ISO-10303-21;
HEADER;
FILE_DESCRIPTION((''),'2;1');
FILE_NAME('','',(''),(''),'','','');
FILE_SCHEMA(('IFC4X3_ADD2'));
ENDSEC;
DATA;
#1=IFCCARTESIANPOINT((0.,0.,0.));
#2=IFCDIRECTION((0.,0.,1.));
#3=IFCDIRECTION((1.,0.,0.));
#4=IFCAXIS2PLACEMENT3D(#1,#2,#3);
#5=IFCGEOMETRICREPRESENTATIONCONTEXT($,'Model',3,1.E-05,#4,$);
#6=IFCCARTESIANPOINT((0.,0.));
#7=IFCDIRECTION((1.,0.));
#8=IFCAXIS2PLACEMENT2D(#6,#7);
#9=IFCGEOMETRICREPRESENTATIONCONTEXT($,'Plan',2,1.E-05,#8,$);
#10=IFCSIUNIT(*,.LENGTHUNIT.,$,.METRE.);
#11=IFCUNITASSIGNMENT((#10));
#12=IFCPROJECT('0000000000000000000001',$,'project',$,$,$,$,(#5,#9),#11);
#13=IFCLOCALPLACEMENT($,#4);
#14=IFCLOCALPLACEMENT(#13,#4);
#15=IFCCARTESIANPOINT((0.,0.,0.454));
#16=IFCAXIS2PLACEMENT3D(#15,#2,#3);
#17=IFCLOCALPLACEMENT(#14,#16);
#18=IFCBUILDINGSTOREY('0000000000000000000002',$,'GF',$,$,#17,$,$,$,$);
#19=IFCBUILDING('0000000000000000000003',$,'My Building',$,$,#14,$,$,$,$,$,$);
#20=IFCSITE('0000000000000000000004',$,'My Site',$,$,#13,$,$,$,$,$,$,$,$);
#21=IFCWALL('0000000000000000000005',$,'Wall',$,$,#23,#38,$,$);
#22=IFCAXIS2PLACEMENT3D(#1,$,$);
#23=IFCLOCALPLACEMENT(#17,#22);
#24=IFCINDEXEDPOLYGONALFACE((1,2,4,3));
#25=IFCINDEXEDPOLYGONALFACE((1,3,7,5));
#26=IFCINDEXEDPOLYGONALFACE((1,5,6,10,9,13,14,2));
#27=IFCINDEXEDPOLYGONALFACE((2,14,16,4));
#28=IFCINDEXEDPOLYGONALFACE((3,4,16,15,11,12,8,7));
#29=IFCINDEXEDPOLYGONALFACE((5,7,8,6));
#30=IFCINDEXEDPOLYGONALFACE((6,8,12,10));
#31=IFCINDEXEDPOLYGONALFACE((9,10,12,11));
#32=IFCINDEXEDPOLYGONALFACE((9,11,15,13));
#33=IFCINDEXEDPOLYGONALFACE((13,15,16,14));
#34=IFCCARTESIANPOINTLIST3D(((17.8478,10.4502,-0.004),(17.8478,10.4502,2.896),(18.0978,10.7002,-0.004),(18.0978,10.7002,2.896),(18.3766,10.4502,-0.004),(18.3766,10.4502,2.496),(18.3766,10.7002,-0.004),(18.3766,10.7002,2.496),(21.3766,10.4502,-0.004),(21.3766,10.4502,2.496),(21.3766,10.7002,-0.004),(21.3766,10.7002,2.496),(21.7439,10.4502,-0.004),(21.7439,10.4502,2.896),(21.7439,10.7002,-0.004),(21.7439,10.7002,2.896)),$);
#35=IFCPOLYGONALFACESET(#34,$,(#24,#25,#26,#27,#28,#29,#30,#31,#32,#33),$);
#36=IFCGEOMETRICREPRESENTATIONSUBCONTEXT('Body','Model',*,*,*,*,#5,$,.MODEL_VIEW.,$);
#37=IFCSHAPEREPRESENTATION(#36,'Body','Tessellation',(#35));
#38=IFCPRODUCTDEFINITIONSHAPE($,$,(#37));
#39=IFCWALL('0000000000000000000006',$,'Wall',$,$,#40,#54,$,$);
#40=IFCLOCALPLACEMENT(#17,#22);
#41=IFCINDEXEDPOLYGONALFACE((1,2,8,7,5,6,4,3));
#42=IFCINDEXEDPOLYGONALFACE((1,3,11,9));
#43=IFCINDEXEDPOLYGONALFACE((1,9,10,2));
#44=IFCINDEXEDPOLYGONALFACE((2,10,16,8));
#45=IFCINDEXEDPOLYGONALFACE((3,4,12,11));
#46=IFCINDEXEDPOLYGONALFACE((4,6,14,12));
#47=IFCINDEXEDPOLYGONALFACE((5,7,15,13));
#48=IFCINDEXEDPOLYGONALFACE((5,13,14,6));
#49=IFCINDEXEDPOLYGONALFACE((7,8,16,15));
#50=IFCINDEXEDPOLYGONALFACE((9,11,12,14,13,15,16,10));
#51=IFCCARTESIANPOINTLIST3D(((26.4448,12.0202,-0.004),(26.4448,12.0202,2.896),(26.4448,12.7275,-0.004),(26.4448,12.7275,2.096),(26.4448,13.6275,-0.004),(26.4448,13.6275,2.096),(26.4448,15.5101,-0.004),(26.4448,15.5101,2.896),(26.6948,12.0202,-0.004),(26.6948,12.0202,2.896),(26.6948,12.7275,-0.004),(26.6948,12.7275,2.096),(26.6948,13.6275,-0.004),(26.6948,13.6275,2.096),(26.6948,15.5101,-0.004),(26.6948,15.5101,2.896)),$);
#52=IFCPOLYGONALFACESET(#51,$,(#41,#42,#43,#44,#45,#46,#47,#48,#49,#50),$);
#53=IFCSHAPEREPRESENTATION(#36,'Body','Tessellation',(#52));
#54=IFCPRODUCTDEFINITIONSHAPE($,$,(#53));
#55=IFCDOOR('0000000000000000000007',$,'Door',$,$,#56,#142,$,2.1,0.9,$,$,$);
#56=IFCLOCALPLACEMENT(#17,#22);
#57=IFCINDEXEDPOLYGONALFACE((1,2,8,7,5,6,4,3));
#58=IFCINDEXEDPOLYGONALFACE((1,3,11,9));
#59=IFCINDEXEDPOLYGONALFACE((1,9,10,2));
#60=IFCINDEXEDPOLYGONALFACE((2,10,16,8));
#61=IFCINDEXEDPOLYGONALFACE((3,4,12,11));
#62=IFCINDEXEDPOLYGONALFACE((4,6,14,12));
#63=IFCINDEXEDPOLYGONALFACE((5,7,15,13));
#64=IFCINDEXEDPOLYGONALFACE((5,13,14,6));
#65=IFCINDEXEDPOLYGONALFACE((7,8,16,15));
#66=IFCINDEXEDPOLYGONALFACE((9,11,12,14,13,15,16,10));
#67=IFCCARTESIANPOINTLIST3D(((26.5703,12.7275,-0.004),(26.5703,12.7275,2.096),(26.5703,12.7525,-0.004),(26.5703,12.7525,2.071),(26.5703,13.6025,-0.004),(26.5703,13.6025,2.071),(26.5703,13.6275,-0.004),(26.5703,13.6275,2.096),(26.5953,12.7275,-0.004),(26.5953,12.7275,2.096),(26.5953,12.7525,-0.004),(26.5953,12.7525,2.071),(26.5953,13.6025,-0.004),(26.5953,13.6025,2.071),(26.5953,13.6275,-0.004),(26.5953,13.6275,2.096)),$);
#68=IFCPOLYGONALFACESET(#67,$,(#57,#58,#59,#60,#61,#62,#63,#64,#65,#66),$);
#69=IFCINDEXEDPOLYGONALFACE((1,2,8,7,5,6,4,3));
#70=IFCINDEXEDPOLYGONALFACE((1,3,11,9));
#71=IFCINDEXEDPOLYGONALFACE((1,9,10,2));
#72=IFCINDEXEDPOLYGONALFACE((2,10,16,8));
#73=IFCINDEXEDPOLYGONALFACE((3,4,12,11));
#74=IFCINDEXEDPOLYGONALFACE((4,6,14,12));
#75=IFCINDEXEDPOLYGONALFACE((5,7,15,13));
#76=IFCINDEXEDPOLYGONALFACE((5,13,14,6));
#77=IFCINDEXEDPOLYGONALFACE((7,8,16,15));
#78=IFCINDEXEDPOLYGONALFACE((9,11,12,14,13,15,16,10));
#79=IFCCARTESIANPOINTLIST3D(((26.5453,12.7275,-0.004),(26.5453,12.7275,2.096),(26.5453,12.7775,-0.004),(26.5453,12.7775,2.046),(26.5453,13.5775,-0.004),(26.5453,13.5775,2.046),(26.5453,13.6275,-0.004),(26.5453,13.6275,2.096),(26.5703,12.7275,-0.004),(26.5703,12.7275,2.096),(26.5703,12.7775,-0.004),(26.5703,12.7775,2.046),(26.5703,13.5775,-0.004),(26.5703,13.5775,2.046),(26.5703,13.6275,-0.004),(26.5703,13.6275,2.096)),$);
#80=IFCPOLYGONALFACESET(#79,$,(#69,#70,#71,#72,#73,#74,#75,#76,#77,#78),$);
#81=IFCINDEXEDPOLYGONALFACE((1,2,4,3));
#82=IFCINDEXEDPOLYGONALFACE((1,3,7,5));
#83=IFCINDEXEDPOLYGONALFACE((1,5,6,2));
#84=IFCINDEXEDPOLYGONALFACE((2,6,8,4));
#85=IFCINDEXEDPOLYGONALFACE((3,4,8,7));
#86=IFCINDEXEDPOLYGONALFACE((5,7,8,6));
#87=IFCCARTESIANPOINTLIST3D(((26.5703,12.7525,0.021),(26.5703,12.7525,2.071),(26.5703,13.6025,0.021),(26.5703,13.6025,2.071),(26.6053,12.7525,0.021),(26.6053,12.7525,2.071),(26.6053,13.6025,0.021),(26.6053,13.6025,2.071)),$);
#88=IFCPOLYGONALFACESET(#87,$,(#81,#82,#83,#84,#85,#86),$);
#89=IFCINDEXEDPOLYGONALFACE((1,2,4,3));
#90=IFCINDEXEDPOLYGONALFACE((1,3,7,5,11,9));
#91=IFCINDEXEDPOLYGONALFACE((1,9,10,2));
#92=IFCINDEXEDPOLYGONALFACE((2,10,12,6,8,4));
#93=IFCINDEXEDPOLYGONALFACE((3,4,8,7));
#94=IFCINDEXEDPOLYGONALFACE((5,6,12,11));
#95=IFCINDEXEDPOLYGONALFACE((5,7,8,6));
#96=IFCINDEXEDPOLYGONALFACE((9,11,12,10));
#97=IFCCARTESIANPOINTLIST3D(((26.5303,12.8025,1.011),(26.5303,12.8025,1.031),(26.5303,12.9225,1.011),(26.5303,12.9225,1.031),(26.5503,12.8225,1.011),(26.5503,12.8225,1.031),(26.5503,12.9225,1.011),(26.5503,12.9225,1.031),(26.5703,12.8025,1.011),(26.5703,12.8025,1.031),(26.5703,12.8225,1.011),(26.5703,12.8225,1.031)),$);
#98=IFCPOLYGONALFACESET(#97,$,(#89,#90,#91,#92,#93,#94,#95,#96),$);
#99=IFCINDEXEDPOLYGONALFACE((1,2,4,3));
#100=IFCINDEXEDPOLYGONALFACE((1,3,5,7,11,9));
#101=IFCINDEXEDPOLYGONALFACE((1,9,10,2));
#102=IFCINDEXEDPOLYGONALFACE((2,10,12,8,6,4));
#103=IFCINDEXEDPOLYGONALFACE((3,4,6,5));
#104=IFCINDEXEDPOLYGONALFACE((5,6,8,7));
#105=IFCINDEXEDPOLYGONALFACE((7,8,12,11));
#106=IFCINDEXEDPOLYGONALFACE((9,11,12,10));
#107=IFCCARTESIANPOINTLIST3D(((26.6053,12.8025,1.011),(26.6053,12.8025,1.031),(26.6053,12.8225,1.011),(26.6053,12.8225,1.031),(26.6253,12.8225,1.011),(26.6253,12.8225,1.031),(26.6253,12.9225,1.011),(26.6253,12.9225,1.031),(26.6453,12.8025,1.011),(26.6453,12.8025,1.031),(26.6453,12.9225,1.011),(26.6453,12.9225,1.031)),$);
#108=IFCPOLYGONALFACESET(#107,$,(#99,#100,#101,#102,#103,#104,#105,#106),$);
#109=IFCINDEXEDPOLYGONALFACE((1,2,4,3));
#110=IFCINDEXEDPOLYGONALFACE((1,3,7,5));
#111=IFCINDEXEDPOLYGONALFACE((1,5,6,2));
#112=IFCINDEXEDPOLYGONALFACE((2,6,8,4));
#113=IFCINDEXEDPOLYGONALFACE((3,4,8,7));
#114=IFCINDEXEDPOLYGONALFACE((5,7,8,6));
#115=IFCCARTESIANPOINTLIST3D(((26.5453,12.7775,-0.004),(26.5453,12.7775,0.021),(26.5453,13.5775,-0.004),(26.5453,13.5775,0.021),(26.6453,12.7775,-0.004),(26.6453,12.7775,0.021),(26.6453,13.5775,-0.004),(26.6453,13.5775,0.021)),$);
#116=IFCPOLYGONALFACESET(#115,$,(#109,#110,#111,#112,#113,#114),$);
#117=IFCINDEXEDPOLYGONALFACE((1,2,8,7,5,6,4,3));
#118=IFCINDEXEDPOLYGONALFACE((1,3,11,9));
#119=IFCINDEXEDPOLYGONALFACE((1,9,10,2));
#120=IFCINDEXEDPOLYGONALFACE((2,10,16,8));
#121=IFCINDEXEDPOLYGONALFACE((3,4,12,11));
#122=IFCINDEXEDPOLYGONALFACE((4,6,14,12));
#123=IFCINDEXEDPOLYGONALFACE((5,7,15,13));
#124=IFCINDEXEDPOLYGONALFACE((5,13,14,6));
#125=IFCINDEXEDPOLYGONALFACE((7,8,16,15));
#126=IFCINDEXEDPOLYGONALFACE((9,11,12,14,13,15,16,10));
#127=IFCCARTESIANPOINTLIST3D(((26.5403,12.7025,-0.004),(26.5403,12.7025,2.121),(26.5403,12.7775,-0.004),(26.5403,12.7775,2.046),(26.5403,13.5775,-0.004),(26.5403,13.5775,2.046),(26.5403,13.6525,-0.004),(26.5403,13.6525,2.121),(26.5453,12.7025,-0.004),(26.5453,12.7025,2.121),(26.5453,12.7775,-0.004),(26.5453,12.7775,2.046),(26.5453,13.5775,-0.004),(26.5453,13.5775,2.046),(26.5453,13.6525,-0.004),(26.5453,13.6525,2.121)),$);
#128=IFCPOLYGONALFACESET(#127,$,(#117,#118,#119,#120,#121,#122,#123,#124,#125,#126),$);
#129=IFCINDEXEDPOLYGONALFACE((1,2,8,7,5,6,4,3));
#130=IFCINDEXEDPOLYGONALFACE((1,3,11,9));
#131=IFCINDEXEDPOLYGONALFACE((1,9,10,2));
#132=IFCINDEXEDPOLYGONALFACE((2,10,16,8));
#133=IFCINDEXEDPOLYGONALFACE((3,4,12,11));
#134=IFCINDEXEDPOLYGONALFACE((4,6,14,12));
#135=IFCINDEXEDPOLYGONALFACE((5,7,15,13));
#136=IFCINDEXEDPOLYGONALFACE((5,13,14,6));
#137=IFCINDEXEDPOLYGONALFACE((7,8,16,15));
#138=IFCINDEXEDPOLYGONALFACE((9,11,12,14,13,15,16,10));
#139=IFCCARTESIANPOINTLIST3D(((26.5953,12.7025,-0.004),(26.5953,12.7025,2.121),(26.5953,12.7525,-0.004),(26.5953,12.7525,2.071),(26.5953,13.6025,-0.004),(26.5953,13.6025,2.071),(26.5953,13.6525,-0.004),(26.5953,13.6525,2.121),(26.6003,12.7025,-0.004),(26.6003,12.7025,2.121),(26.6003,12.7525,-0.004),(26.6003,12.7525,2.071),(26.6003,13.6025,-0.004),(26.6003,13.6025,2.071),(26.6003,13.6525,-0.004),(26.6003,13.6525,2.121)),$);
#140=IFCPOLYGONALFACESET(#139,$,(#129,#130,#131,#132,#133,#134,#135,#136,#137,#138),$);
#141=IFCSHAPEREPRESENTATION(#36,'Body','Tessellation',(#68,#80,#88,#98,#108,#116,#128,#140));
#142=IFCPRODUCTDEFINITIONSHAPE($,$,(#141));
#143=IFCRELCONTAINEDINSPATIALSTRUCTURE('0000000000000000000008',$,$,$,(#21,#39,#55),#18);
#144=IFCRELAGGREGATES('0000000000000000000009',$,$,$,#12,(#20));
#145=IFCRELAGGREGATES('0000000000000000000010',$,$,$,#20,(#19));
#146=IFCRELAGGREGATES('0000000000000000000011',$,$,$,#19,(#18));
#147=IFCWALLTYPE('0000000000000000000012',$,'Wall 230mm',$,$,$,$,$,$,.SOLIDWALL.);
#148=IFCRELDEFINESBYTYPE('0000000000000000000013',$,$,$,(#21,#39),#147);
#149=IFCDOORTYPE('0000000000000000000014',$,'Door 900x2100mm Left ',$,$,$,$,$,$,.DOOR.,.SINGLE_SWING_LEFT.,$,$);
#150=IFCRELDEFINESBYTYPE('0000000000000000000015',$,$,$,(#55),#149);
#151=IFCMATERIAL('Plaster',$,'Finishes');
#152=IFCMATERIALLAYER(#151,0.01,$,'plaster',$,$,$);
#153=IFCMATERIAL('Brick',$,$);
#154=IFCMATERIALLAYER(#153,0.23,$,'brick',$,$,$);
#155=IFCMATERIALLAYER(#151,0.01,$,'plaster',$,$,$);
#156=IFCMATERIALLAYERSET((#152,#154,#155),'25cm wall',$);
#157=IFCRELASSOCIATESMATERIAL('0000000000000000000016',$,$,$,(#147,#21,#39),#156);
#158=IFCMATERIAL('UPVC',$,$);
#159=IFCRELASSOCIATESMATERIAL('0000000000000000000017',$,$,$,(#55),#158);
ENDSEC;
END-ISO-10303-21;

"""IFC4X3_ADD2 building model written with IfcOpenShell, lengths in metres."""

from ifc_helpers import new_model, entity, si_unit, frame, origin_with_axes, origin_2d_with_axis, place, context, subcontext, project, spatial, line, indexed_curve, outline, extrude, shape, source, transform, mapped, material, layer, layer_set, layer_usage, type_object, type_shapes, element, fill, save


model = new_model("IFC4X3_ADD2")

# Units and contexts
model_context = context("Model", 3, precision=1e-05, world=origin_with_axes())
plan_context = context("Plan", 2, precision=1e-05, world=origin_2d_with_axis())
body_context_1 = subcontext(model_context, "Body", "Model", "MODEL_VIEW")
body_context_2 = subcontext(plan_context, "Body", "Plan", "PLAN_VIEW")
ifc_project = project(units=[si_unit("LENGTHUNIT", "METRE")], contexts=[model_context, plan_context])

# Site, building, storey
site_placement = place(None, origin_with_axes())
site = spatial("IfcSite", under=ifc_project, at=site_placement, Name="My Site")
building_placement = place(site_placement, origin_with_axes())
building = spatial("IfcBuilding", under=site, at=building_placement, Name="My Building")
storey_placement = place(building_placement, frame((0.0, 0.0, 0.454), z_axis=(0.0, 0.0, 1.0), x_axis=(1.0, 0.0, 0.0)))
storey = spatial("IfcBuildingStorey", under=building, at=storey_placement, Name="GF")

# Shared definitions
ifc_material_1 = material(Name="UPVC")

# Wall, opening
ifc_material_2 = material(Name="Plaster", Category="Finishes")
ifc_layer_1 = layer(ifc_material_2, 0.01, Name="plaster")
ifc_material_3 = material(Name="Brick")
ifc_layer_2 = layer(ifc_material_3, 0.23, Name="brick")
ifc_layer_3 = layer(ifc_material_2, 0.01, Name="plaster")
ifc_layer_set = layer_set([ifc_layer_1, ifc_layer_2, ifc_layer_3], Name="25cm wall")
ifc_layer_usage_1 = layer_usage(ifc_layer_set, "AXIS2", "NEGATIVE", 0.0)
wall_type = type_object("IfcWallType", Name="Wall 230mm", PredefinedType="SOLIDWALL", material=ifc_layer_set)
wall_1_placement = place(storey_placement, frame((21.7439, 10.4502, -0.004), z_axis=(0.0, 0.0, 1.0), x_axis=(-1.0, 0.0, 0.0)))
wall_1 = element("IfcWall", 1, at=wall_1_placement, inside=storey, type_object=wall_type, material=ifc_layer_usage_1, Name="Wall", context=body_context_1, shape_type="SweptSolid", body=[
    extrude(outline(indexed_curve([(0.0, -0.25), (0.0, 0.0), (3.8962, 0.0), (3.6462, -0.25)], segments=[line(1, 2, 3, 4, 1)])), origin_with_axes(), (0.0, 0.0, 1.0), 2.9),
])
shared_shape_1 = source(origin_with_axes(), body_context_1, "Body", "SweptSolid", [
    extrude(outline(indexed_curve([(0.0, 0.0), (3.0, 0.0), (3.0, 2.5), (0.0, 2.5)], segments=[line(1, 2, 3, 4, 1)])), frame((0.0, -0.6, 0.0), z_axis=(0.0, -1.0, 0.0), x_axis=(1.0, 0.0, 0.0)), (0.0, 0.0, -1.0), 1.2),
])
opening_1_placement = place(wall_1_placement, frame((0.3674, 0.0, 0.0), z_axis=(0.0, 0.0, 1.0), x_axis=(1.0, 0.0, 0.0)))
element("IfcOpeningElement", 2, at=opening_1_placement, cuts=wall_1, PredefinedType="OPENING", context=body_context_1, shape_type="MappedRepresentation", body=[
    mapped(shared_shape_1, transform((0.0, 0.0, 0.0), x_axis=(1.0, 0.0, 0.0), y_axis=(0.0, 1.0, 0.0), z_axis=(0.0, 0.0, 1.0), scale=1.0)),
])

# Wall, opening, door
ifc_layer_usage_2 = layer_usage(ifc_layer_set, "AXIS2", "POSITIVE", 0.0)
wall_2_placement = place(storey_placement, frame((26.6948, 12.0202, -0.004), z_axis=(0.0, 0.0, 1.0), x_axis=(0.000001, 1.0, 0.0)))
wall_2 = element("IfcWall", 3, at=wall_2_placement, inside=storey, type_object=wall_type, material=ifc_layer_usage_2, Name="Wall", context=body_context_1, shape_type="SweptSolid", body=[
    extrude(outline(indexed_curve([(0.0, 0.0), (0.0, 0.25), (3.4899, 0.25), (3.4899, 0.0)], segments=[line(1, 2, 3, 4, 1)])), origin_with_axes(), (0.0, 0.0, 1.0), 2.9),
])
shared_shape_2 = source(origin_with_axes(), body_context_1, "Body", "SweptSolid", [
    extrude(outline(indexed_curve([(0.0, 0.0), (0.9, 0.0), (0.9, 2.1), (0.0, 2.1)], segments=[line(1, 2, 3, 4, 1)])), frame((0.0, -0.6, 0.0), z_axis=(0.0, -1.0, 0.0), x_axis=(1.0, 0.0, 0.0)), (0.0, 0.0, -1.0), 1.2),
])
opening_2_placement = place(wall_2_placement, frame((1.6073, 0.1495, 0.0), z_axis=(0.0, 0.0, 1.0), x_axis=(-1.0, 0.0, 0.0)))
opening_2 = element("IfcOpeningElement", 4, at=opening_2_placement, cuts=wall_2, PredefinedType="OPENING", context=body_context_1, shape_type="MappedRepresentation", body=[
    mapped(shared_shape_2, transform((0.0, 0.0, 0.0), x_axis=(1.0, 0.0, 0.0), y_axis=(0.0, 1.0, 0.0), z_axis=(0.0, 0.0, 1.0), scale=1.0)),
])
door_type = type_object("IfcDoorType", Name="Door 900x2100mm Left ", OperationType="SINGLE_SWING_LEFT", PredefinedType="DOOR")
shared_shape_3 = source(origin_with_axes(), body_context_1, "Body", "SweptSolid", [
    extrude(outline(indexed_curve([(0.0, 0.0), (0.0, 2.1), (0.9, 2.1), (0.9, 0.0), (0.875, 0.0), (0.875, 2.075), (0.025, 2.075), (0.025, 0.0)], segments=[line(1, 2, 3, 4, 5, 6, 7, 8, 1)])), frame((0.0, 0.025, 0.0), z_axis=(0.0, -1.0, 0.0), x_axis=(1.0, 0.0, 0.0)), (0.0, 0.0, -1.0), 0.025),
    extrude(outline(indexed_curve([(0.0, 0.0), (0.0, 2.1), (0.9, 2.1), (0.9, 0.0), (0.85, 0.0), (0.85, 2.05), (0.05, 2.05), (0.05, 0.0)], segments=[line(1, 2, 3, 4, 5, 6, 7, 8, 1)])), frame((0.0, 0.0, 0.0), z_axis=(0.0, -1.0, 0.0), x_axis=(1.0, 0.0, 0.0)), (0.0, 0.0, -1.0), 0.025),
    extrude(outline(indexed_curve([(0.0, 0.0), (0.85, 0.0), (0.85, 0.035), (0.0, 0.035)], segments=[line(1, 2, 3, 4, 1)])), frame((0.025, 0.025, 0.025), z_axis=(0.0, 0.0, 1.0), x_axis=(1.0, 0.0, 0.0)), (0.0, 0.0, 1.0), 2.05),
    extrude(outline(indexed_curve([(0.0, 0.0), (0.0, -0.04), (-0.12, -0.04), (-0.12, -0.02), (-0.02, -0.02), (-0.02, 0.0)], segments=[line(1, 2, 3, 4, 5, 6, 1)])), frame((0.825, 0.025, 1.015), z_axis=(0.0, 0.0, 1.0), x_axis=(1.0, 0.0, 0.0)), (0.0, 0.0, 1.0), 0.02),
    extrude(outline(indexed_curve([(0.0, 0.0), (0.0, 0.04), (-0.12, 0.04), (-0.12, 0.02), (-0.02, 0.02), (-0.02, 0.0)], segments=[line(1, 2, 3, 4, 5, 6, 1)])), frame((0.825, 0.06, 1.015), z_axis=(0.0, 0.0, 1.0), x_axis=(1.0, 0.0, 0.0)), (0.0, 0.0, 1.0), 0.02),
    extrude(outline(indexed_curve([(0.0, 0.0), (0.8, 0.0), (0.8, 0.1), (0.0, 0.1)], segments=[line(1, 2, 3, 4, 1)])), frame((0.05, 0.0, 0.0), z_axis=(0.0, 0.0, 1.0), x_axis=(1.0, 0.0, 0.0)), (0.0, 0.0, 1.0), 0.025),
    extrude(outline(indexed_curve([(0.0, 0.0), (0.0, 2.125), (0.95, 2.125), (0.95, 0.0), (0.875, 0.0), (0.875, 2.05), (0.075, 2.05), (0.075, 0.0)], segments=[line(1, 2, 3, 4, 5, 6, 7, 8, 1)])), frame((-0.025, -0.005, 0.0), z_axis=(0.0, -1.0, 0.0), x_axis=(1.0, 0.0, 0.0)), (0.0, 0.0, -1.0), 0.005),
    extrude(outline(indexed_curve([(0.0, 0.0), (0.0, 2.125), (0.95, 2.125), (0.95, 0.0), (0.9, 0.0), (0.9, 2.075), (0.05, 2.075), (0.05, 0.0)], segments=[line(1, 2, 3, 4, 5, 6, 7, 8, 1)])), frame((-0.025, 0.05, 0.0), z_axis=(0.0, -1.0, 0.0), x_axis=(1.0, 0.0, 0.0)), (0.0, 0.0, -1.0), 0.005),
])
shared_shape_4 = source(origin_with_axes(), body_context_2, "Body", "Curve2D", [
    entity("IfcIndexedPolyCurve", entity("IfcCartesianPointList2D", [[0.0, 0.0], [0.0, 0.05], [0.025, 0.05], [0.025, 0.025], [0.05, 0.025], [0.05, 0.0]]), [entity("IfcLineIndex", [1, 2, 3, 4, 5, 6, 1])]),
    entity("IfcIndexedPolyCurve", entity("IfcCartesianPointList2D", [[0.9, 0.0], [0.9, 0.05], [0.875, 0.05], [0.875, 0.025], [0.85, 0.025], [0.85, 0.0]]), [entity("IfcLineIndex", [1, 2, 3, 4, 5, 6, 1])]),
    entity("IfcTrimmedCurve", entity("IfcEllipse", entity("IfcAxis2Placement2D", entity("IfcCartesianPoint", [0.06, 0.05]), entity("IfcDirection", [1.0, 0.0])), 0.815, 0.85), [entity("IfcCartesianPoint", [0.875, 0.05])], [entity("IfcCartesianPoint", [0.06, 0.9])], True, "CARTESIAN"),
    entity("IfcIndexedPolyCurve", entity("IfcCartesianPointList2D", [[0.025, 0.05], [0.06, 0.05], [0.06, 0.9], [0.025, 0.9]]), [entity("IfcLineIndex", [1, 2, 3, 4, 1])]),
])
type_shapes(door_type, [shared_shape_3, shared_shape_4])
door_placement = place(opening_2_placement, origin_with_axes())
door = element("IfcDoor", 5, at=door_placement, inside=storey, type_object=door_type, material=ifc_material_1, Name="Door", OverallHeight=2.1, OverallWidth=0.9, shapes=[
    shape(body_context_1, "Body", "MappedRepresentation", [mapped(shared_shape_3, transform((0.0, 0.0, 0.0), x_axis=(1.0, 0.0, 0.0), y_axis=(0.0, 1.0, 0.0), z_axis=(0.0, 0.0, 1.0), scale=1.0))]),
    shape(body_context_2, "Body", "MappedRepresentation", [mapped(shared_shape_4, transform((0.0, 0.0, 0.0), x_axis=(1.0, 0.0, 0.0), y_axis=(0.0, 1.0, 0.0), z_axis=(0.0, 0.0, 1.0), scale=1.0))]),
])
fill(opening_2, door)

save(model, "model.ifc")
